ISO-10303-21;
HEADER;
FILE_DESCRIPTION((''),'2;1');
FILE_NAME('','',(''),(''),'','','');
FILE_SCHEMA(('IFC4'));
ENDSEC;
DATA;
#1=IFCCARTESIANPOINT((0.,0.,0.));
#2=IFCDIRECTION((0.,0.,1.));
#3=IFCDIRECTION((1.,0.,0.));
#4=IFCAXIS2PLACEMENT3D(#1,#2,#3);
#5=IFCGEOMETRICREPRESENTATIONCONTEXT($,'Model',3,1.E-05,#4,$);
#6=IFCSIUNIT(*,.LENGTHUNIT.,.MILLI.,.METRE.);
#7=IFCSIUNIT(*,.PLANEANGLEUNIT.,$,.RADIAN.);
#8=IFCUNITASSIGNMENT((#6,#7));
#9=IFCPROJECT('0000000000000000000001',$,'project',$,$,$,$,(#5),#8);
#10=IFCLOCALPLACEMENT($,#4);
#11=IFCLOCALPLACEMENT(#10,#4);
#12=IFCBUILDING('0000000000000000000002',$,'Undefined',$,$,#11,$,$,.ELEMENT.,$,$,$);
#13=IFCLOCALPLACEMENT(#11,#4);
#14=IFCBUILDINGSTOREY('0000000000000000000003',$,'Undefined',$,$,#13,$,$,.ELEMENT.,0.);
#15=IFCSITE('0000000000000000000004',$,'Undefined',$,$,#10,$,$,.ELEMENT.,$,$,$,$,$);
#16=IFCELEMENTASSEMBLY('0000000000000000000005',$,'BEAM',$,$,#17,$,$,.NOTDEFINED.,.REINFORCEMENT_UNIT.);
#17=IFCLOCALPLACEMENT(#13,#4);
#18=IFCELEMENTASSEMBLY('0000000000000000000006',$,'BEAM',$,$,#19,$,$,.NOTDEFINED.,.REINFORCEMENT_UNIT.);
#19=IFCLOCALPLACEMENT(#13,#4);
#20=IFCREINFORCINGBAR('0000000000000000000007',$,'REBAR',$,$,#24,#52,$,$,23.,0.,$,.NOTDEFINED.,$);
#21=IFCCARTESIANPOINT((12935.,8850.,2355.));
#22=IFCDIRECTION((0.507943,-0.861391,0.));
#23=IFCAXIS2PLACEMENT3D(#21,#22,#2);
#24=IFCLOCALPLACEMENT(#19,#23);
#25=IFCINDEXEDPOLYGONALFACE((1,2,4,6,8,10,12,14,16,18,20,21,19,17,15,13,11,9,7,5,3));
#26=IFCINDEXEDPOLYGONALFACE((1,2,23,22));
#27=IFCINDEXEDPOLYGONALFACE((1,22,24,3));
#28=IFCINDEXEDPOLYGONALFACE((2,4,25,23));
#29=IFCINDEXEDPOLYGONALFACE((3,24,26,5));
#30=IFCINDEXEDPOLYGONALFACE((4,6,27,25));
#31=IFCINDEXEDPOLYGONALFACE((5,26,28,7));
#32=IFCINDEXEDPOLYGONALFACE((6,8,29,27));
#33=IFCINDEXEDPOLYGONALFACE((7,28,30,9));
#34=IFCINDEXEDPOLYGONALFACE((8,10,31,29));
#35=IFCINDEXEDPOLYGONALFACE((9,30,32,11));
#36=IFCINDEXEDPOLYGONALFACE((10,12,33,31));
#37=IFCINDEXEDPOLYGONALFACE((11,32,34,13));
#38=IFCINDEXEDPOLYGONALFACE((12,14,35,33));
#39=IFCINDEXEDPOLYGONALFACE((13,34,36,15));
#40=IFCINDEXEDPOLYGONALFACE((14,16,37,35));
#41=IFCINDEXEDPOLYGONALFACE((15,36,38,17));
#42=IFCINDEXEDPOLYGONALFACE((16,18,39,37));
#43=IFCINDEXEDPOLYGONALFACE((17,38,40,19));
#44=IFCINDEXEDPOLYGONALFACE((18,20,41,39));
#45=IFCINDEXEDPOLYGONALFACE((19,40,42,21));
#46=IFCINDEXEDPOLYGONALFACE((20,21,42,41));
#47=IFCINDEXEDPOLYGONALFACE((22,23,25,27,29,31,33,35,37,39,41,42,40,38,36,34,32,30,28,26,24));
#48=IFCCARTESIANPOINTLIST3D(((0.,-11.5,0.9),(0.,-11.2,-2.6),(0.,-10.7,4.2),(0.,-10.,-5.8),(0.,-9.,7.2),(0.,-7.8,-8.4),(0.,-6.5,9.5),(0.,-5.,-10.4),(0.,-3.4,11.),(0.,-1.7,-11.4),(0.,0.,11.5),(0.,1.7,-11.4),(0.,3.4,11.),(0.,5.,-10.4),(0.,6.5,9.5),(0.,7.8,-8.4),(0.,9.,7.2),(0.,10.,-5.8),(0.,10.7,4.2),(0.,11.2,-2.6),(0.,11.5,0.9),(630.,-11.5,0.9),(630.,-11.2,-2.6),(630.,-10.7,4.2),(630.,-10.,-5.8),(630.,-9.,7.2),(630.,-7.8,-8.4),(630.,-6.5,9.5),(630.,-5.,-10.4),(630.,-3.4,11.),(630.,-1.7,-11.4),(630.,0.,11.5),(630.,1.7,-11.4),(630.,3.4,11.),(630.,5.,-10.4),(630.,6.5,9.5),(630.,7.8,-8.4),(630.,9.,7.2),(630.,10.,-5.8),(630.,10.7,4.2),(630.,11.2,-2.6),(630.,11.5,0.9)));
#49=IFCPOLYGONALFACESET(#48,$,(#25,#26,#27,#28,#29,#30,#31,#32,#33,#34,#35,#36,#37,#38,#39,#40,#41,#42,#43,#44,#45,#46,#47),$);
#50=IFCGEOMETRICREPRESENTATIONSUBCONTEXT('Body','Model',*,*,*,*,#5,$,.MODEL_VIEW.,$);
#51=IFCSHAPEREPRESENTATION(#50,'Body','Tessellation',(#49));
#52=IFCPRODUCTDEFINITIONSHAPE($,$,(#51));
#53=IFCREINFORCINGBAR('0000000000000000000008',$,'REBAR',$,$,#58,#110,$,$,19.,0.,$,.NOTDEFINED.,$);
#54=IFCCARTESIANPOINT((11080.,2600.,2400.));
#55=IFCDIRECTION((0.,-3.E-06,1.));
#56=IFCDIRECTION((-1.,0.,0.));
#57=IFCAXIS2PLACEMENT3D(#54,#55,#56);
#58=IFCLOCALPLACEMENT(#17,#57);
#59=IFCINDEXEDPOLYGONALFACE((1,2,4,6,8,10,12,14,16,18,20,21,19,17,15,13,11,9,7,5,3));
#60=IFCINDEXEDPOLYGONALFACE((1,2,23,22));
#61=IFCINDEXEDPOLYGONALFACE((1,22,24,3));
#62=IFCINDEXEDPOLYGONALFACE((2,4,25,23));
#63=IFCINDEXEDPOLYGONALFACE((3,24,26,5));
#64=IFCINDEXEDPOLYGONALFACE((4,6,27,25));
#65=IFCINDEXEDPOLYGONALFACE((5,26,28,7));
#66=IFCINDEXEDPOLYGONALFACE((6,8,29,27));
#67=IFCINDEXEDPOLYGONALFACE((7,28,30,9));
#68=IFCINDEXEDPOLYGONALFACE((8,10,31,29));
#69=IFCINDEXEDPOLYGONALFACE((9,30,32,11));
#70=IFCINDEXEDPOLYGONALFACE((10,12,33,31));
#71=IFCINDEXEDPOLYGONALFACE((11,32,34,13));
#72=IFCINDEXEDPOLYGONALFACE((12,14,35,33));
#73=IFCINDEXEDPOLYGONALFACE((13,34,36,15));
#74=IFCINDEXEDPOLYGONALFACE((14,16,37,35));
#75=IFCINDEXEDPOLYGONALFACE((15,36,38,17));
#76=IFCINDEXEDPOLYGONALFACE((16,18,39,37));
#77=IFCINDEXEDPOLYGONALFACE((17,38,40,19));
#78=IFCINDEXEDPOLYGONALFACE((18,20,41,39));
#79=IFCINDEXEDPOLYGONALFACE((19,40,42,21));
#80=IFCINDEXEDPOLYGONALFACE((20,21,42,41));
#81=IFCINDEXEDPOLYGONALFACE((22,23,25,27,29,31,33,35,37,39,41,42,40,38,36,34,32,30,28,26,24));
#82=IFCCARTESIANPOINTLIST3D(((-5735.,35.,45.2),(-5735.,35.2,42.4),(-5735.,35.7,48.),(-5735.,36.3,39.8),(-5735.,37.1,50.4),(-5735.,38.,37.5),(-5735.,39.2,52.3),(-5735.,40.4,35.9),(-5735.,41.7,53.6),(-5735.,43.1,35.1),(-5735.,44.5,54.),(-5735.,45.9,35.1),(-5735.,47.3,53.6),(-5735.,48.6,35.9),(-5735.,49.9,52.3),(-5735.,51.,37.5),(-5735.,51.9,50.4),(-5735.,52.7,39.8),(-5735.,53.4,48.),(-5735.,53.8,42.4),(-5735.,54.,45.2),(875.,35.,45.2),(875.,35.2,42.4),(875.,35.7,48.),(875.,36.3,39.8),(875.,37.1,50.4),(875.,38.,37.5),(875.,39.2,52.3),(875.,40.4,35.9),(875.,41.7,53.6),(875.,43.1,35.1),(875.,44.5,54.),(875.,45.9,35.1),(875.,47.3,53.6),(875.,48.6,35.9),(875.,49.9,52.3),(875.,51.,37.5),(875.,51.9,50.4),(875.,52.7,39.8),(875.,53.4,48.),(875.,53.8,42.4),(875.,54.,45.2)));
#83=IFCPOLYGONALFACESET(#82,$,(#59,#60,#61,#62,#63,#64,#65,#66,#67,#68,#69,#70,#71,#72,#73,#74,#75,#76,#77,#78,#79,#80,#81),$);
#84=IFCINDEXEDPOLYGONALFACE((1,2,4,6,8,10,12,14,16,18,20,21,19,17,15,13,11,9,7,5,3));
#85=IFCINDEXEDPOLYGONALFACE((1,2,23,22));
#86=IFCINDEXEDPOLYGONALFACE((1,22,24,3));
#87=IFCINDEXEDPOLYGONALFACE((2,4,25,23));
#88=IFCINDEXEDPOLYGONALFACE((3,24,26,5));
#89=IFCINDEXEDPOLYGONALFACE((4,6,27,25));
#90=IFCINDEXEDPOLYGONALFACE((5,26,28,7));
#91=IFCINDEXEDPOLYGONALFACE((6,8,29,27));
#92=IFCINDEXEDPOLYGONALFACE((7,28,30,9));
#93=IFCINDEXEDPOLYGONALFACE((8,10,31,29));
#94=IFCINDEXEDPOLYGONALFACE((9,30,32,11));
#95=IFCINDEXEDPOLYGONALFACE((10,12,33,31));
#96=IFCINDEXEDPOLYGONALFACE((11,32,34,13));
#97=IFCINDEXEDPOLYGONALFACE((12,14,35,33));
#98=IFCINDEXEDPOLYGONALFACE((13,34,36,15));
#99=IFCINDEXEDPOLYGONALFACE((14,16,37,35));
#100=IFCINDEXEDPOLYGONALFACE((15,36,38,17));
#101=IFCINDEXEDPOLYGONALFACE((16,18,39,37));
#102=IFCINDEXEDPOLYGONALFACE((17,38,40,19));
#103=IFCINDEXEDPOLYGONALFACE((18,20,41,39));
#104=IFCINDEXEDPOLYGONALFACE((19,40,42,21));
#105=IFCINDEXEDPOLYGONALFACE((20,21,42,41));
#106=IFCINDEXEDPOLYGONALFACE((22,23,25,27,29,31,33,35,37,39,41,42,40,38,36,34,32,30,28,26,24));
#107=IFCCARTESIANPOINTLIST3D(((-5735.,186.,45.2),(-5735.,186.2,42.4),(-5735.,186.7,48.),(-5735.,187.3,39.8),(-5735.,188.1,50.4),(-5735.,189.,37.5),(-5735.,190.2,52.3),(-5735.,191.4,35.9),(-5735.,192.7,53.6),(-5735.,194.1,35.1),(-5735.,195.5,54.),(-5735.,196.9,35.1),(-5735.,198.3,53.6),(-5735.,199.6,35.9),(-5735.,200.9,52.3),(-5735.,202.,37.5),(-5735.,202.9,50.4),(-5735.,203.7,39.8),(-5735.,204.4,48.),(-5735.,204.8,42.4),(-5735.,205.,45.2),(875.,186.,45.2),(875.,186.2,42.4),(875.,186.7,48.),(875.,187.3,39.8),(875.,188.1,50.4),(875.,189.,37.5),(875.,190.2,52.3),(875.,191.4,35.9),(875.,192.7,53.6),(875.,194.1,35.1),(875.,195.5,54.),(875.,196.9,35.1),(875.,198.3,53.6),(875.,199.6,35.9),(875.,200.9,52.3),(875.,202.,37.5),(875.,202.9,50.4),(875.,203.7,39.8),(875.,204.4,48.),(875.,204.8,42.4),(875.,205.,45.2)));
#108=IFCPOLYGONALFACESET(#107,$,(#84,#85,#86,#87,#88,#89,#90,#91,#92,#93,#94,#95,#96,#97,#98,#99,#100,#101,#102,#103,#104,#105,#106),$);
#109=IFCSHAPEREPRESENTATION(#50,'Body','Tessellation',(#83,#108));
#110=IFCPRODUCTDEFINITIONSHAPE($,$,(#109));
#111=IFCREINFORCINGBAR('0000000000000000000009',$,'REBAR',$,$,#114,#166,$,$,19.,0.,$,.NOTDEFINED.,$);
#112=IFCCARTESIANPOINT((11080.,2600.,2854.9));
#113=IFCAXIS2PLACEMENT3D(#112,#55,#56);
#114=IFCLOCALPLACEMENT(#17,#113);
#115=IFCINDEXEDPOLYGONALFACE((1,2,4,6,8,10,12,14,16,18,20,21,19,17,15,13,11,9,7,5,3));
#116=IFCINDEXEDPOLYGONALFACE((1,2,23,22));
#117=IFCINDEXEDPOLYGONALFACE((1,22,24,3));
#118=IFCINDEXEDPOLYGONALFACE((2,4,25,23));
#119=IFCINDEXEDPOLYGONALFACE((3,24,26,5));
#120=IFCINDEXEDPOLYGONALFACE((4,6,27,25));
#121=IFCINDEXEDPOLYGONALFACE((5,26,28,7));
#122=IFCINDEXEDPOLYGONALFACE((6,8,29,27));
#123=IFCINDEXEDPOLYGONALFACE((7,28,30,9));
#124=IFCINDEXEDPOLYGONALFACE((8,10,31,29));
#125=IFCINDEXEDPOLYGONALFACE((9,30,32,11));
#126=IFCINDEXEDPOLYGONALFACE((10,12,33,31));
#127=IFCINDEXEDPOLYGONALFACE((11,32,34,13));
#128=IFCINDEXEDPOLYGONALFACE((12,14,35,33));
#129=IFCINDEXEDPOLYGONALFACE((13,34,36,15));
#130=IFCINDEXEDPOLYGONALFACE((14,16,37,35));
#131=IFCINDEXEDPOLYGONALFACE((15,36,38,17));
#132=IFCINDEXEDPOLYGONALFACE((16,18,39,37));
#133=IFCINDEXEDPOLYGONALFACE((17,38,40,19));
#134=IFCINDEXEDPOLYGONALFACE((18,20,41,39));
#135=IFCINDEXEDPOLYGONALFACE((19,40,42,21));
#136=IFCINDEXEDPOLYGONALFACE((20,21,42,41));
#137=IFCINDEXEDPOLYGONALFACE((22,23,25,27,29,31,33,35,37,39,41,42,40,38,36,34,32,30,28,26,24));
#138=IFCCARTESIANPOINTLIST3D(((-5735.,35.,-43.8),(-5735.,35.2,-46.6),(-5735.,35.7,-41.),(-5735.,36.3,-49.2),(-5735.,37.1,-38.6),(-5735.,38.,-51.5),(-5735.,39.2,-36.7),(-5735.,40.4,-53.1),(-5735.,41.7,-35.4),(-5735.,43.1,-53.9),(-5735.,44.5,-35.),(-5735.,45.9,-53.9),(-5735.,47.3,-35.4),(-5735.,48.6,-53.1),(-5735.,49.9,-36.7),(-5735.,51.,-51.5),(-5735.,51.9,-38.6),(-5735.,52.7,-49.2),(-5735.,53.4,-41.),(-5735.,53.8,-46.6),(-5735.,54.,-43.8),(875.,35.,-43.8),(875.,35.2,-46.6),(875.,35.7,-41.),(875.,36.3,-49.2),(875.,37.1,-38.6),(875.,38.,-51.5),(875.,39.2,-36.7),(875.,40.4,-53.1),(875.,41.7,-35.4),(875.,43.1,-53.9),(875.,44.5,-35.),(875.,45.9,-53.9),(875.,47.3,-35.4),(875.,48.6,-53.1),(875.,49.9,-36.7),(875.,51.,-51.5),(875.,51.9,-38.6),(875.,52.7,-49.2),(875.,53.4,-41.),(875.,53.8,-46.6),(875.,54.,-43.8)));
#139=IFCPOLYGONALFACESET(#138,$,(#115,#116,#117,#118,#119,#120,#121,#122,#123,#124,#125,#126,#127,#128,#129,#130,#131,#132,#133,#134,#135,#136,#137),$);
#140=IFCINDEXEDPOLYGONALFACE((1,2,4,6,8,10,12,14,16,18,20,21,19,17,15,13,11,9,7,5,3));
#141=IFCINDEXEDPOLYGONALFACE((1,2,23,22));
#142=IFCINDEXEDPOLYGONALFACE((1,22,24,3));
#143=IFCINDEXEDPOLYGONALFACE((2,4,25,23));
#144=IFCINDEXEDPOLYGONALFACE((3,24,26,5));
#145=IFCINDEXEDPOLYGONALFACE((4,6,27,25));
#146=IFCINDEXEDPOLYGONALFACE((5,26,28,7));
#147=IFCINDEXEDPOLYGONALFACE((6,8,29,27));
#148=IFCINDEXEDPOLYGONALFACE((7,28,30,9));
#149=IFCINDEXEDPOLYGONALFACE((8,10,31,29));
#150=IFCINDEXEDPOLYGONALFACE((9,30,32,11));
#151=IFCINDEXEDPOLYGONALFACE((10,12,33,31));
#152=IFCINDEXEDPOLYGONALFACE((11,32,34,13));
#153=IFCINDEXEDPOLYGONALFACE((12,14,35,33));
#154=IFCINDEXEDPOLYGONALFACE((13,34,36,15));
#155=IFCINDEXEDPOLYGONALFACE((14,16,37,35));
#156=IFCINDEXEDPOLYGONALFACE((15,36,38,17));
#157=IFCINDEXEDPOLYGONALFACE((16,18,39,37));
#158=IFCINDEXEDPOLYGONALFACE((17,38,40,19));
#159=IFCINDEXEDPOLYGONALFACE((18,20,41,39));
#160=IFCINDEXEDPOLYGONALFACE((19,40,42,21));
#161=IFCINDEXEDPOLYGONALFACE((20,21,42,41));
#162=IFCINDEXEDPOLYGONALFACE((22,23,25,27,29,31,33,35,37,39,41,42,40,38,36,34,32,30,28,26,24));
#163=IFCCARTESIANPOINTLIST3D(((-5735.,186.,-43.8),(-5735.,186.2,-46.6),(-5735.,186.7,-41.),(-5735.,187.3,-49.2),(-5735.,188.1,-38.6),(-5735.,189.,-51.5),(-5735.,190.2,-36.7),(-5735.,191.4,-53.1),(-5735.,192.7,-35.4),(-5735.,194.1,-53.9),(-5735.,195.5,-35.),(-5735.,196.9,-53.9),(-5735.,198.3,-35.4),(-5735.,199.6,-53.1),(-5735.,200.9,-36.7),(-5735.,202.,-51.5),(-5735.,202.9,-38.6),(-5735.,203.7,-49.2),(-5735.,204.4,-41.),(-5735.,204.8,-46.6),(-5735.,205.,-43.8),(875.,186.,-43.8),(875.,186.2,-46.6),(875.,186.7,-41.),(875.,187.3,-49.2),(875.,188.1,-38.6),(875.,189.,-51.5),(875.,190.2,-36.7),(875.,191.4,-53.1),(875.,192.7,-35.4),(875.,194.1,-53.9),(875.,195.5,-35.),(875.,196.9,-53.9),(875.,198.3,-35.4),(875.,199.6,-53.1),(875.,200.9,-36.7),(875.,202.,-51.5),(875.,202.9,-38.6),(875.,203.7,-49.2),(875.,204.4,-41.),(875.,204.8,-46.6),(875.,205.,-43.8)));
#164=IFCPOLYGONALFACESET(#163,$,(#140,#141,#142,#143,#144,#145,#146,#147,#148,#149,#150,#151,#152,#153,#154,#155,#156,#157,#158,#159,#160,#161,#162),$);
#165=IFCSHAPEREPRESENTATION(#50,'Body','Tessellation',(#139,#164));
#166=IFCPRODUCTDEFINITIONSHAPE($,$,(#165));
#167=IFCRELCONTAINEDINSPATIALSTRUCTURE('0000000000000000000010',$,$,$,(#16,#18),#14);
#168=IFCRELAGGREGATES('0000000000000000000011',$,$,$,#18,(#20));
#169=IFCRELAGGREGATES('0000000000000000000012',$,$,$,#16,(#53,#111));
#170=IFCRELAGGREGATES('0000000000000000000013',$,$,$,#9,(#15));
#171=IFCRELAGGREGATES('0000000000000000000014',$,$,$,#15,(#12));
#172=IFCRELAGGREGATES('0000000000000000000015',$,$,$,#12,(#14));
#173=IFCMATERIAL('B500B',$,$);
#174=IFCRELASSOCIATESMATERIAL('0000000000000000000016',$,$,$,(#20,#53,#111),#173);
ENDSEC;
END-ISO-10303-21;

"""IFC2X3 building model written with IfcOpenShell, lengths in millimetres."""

from ifc_helpers import new_model, entity, si_unit, frame, origin_with_axes, place, context, subcontext, project, spatial, source, transform, mapped, material, element, aggregate, save


model = new_model("IFC2X3")

# Units and contexts
model_context = context("Model", 3, precision=1e-05, world=origin_with_axes())
body_context = subcontext(model_context, "Body", "Model", "MODEL_VIEW")
ifc_project = project(units=[si_unit("LENGTHUNIT", "METRE", prefix="MILLI"), si_unit("PLANEANGLEUNIT", "RADIAN")], contexts=[model_context])

# Site, building, storey
site_placement = place(None, origin_with_axes())
site = spatial("IfcSite", under=ifc_project, at=site_placement, Name="Undefined", CompositionType="ELEMENT")
building_placement = place(site_placement, origin_with_axes())
building = spatial("IfcBuilding", under=site, at=building_placement, Name="Undefined", CompositionType="ELEMENT")
storey_placement = place(building_placement, origin_with_axes())
storey = spatial("IfcBuildingStorey", under=building, at=storey_placement, Name="Undefined", CompositionType="ELEMENT", Elevation=0.0)

# Element assembly
assembly_1_placement = place(storey_placement, origin_with_axes())
assembly_1 = element("IfcElementAssembly", 1, at=assembly_1_placement, inside=storey, Name="BEAM", AssemblyPlace="NOTDEFINED", PredefinedType="REINFORCEMENT_UNIT")

# Element assembly
assembly_2_placement = place(storey_placement, origin_with_axes())
assembly_2 = element("IfcElementAssembly", 2, at=assembly_2_placement, inside=storey, Name="BEAM", AssemblyPlace="NOTDEFINED", PredefinedType="REINFORCEMENT_UNIT")

# Reinforcing bars
ifc_material_1 = material(Name="B500B")
shared_shape_1 = source(origin_with_axes(), body_context, "Body", "AdvancedSweptSolid", [
    entity("IfcSweptDiskSolid", entity("IfcTrimmedCurve", entity("IfcLine", entity("IfcCartesianPoint", [0.0, 0.0, 0.0]), entity("IfcVector", entity("IfcDirection", [1.0, 0.0, 0.0]), 1.0)), [entity("IfcParameterValue", 0.0)], [entity("IfcParameterValue", 630.0)], True, "PARAMETER"), 11.5, None, 0.0, 630.0),
])
reinforcing_bar_1_placement = place(assembly_2_placement, frame((12935.0, 8850.0, 2355.0), z_axis=(0.507943, -0.861391, 0.0), x_axis=(0.0, 0.0, 1.0)))
reinforcing_bar_1 = element("IfcReinforcingBar", 3, at=reinforcing_bar_1_placement, material=ifc_material_1, Name="REBAR", BarRole="NOTDEFINED", CrossSectionArea=0.0, NominalDiameter=23.0, context=body_context, shape_type="MappedRepresentation", body=[
    mapped(shared_shape_1, transform((0.0, 0.0, 0.0))),
])
aggregate(assembly_2, [reinforcing_bar_1])
shared_shape_2 = source(origin_with_axes(), body_context, "Body", "AdvancedSweptSolid", [
    entity("IfcSweptDiskSolid", entity("IfcTrimmedCurve", entity("IfcLine", entity("IfcCartesianPoint", [0.0, 0.0, 0.0]), entity("IfcVector", entity("IfcDirection", [1.0, 0.0, 0.0]), 1.0)), [entity("IfcParameterValue", 0.0)], [entity("IfcParameterValue", 6609.992834)], True, "PARAMETER"), 9.5, None, 0.0, 6610.0),
])
shared_shape_3 = source(origin_with_axes(), body_context, "Body", "AdvancedSweptSolid", [
    entity("IfcSweptDiskSolid", entity("IfcTrimmedCurve", entity("IfcLine", entity("IfcCartesianPoint", [0.0, 0.0, 0.0]), entity("IfcVector", entity("IfcDirection", [1.0, 0.0, 0.0]), 1.0)), [entity("IfcParameterValue", 0.0)], [entity("IfcParameterValue", 6609.992834)], True, "PARAMETER"), 9.5, None, 0.0, 6610.0),
])
reinforcing_bar_2_placement = place(assembly_1_placement, frame((11080.0, 2600.0, 2400.0), z_axis=(0.0, -0.000003, 1.0), x_axis=(-1.0, 0.0, 0.0)))
reinforcing_bar_2 = element("IfcReinforcingBar", 4, at=reinforcing_bar_2_placement, material=ifc_material_1, Name="REBAR", BarRole="NOTDEFINED", CrossSectionArea=0.0, NominalDiameter=19.0, context=body_context, shape_type="MappedRepresentation", body=[
    mapped(shared_shape_2, transform((-5735.0, 44.5, 44.5))),
    mapped(shared_shape_3, transform((-5735.0, 195.5, 44.5))),
])
shared_shape_4 = source(origin_with_axes(), body_context, "Body", "AdvancedSweptSolid", [
    entity("IfcSweptDiskSolid", entity("IfcTrimmedCurve", entity("IfcLine", entity("IfcCartesianPoint", [0.0, 0.0, 0.0]), entity("IfcVector", entity("IfcDirection", [1.0, 0.0, 0.0]), 1.0)), [entity("IfcParameterValue", 0.0)], [entity("IfcParameterValue", 6609.992834)], True, "PARAMETER"), 9.5, None, 0.0, 6610.0),
])
shared_shape_5 = source(origin_with_axes(), body_context, "Body", "AdvancedSweptSolid", [
    entity("IfcSweptDiskSolid", entity("IfcTrimmedCurve", entity("IfcLine", entity("IfcCartesianPoint", [0.0, 0.0, 0.0]), entity("IfcVector", entity("IfcDirection", [1.0, 0.0, 0.0]), 1.0)), [entity("IfcParameterValue", 0.0)], [entity("IfcParameterValue", 6609.992834)], True, "PARAMETER"), 9.5, None, 0.0, 6610.0),
])
reinforcing_bar_3_placement = place(assembly_1_placement, frame((11080.0, 2600.0, 2854.9), z_axis=(0.0, -0.000003, 1.0), x_axis=(-1.0, 0.0, 0.0)))
reinforcing_bar_3 = element("IfcReinforcingBar", 5, at=reinforcing_bar_3_placement, material=ifc_material_1, Name="REBAR", BarRole="NOTDEFINED", CrossSectionArea=0.0, NominalDiameter=19.0, context=body_context, shape_type="MappedRepresentation", body=[
    mapped(shared_shape_4, transform((-5735.0, 44.5, -44.5))),
    mapped(shared_shape_5, transform((-5735.0, 195.5, -44.5))),
])
aggregate(assembly_1, [reinforcing_bar_2, reinforcing_bar_3])

save(model, "model.ifc")
